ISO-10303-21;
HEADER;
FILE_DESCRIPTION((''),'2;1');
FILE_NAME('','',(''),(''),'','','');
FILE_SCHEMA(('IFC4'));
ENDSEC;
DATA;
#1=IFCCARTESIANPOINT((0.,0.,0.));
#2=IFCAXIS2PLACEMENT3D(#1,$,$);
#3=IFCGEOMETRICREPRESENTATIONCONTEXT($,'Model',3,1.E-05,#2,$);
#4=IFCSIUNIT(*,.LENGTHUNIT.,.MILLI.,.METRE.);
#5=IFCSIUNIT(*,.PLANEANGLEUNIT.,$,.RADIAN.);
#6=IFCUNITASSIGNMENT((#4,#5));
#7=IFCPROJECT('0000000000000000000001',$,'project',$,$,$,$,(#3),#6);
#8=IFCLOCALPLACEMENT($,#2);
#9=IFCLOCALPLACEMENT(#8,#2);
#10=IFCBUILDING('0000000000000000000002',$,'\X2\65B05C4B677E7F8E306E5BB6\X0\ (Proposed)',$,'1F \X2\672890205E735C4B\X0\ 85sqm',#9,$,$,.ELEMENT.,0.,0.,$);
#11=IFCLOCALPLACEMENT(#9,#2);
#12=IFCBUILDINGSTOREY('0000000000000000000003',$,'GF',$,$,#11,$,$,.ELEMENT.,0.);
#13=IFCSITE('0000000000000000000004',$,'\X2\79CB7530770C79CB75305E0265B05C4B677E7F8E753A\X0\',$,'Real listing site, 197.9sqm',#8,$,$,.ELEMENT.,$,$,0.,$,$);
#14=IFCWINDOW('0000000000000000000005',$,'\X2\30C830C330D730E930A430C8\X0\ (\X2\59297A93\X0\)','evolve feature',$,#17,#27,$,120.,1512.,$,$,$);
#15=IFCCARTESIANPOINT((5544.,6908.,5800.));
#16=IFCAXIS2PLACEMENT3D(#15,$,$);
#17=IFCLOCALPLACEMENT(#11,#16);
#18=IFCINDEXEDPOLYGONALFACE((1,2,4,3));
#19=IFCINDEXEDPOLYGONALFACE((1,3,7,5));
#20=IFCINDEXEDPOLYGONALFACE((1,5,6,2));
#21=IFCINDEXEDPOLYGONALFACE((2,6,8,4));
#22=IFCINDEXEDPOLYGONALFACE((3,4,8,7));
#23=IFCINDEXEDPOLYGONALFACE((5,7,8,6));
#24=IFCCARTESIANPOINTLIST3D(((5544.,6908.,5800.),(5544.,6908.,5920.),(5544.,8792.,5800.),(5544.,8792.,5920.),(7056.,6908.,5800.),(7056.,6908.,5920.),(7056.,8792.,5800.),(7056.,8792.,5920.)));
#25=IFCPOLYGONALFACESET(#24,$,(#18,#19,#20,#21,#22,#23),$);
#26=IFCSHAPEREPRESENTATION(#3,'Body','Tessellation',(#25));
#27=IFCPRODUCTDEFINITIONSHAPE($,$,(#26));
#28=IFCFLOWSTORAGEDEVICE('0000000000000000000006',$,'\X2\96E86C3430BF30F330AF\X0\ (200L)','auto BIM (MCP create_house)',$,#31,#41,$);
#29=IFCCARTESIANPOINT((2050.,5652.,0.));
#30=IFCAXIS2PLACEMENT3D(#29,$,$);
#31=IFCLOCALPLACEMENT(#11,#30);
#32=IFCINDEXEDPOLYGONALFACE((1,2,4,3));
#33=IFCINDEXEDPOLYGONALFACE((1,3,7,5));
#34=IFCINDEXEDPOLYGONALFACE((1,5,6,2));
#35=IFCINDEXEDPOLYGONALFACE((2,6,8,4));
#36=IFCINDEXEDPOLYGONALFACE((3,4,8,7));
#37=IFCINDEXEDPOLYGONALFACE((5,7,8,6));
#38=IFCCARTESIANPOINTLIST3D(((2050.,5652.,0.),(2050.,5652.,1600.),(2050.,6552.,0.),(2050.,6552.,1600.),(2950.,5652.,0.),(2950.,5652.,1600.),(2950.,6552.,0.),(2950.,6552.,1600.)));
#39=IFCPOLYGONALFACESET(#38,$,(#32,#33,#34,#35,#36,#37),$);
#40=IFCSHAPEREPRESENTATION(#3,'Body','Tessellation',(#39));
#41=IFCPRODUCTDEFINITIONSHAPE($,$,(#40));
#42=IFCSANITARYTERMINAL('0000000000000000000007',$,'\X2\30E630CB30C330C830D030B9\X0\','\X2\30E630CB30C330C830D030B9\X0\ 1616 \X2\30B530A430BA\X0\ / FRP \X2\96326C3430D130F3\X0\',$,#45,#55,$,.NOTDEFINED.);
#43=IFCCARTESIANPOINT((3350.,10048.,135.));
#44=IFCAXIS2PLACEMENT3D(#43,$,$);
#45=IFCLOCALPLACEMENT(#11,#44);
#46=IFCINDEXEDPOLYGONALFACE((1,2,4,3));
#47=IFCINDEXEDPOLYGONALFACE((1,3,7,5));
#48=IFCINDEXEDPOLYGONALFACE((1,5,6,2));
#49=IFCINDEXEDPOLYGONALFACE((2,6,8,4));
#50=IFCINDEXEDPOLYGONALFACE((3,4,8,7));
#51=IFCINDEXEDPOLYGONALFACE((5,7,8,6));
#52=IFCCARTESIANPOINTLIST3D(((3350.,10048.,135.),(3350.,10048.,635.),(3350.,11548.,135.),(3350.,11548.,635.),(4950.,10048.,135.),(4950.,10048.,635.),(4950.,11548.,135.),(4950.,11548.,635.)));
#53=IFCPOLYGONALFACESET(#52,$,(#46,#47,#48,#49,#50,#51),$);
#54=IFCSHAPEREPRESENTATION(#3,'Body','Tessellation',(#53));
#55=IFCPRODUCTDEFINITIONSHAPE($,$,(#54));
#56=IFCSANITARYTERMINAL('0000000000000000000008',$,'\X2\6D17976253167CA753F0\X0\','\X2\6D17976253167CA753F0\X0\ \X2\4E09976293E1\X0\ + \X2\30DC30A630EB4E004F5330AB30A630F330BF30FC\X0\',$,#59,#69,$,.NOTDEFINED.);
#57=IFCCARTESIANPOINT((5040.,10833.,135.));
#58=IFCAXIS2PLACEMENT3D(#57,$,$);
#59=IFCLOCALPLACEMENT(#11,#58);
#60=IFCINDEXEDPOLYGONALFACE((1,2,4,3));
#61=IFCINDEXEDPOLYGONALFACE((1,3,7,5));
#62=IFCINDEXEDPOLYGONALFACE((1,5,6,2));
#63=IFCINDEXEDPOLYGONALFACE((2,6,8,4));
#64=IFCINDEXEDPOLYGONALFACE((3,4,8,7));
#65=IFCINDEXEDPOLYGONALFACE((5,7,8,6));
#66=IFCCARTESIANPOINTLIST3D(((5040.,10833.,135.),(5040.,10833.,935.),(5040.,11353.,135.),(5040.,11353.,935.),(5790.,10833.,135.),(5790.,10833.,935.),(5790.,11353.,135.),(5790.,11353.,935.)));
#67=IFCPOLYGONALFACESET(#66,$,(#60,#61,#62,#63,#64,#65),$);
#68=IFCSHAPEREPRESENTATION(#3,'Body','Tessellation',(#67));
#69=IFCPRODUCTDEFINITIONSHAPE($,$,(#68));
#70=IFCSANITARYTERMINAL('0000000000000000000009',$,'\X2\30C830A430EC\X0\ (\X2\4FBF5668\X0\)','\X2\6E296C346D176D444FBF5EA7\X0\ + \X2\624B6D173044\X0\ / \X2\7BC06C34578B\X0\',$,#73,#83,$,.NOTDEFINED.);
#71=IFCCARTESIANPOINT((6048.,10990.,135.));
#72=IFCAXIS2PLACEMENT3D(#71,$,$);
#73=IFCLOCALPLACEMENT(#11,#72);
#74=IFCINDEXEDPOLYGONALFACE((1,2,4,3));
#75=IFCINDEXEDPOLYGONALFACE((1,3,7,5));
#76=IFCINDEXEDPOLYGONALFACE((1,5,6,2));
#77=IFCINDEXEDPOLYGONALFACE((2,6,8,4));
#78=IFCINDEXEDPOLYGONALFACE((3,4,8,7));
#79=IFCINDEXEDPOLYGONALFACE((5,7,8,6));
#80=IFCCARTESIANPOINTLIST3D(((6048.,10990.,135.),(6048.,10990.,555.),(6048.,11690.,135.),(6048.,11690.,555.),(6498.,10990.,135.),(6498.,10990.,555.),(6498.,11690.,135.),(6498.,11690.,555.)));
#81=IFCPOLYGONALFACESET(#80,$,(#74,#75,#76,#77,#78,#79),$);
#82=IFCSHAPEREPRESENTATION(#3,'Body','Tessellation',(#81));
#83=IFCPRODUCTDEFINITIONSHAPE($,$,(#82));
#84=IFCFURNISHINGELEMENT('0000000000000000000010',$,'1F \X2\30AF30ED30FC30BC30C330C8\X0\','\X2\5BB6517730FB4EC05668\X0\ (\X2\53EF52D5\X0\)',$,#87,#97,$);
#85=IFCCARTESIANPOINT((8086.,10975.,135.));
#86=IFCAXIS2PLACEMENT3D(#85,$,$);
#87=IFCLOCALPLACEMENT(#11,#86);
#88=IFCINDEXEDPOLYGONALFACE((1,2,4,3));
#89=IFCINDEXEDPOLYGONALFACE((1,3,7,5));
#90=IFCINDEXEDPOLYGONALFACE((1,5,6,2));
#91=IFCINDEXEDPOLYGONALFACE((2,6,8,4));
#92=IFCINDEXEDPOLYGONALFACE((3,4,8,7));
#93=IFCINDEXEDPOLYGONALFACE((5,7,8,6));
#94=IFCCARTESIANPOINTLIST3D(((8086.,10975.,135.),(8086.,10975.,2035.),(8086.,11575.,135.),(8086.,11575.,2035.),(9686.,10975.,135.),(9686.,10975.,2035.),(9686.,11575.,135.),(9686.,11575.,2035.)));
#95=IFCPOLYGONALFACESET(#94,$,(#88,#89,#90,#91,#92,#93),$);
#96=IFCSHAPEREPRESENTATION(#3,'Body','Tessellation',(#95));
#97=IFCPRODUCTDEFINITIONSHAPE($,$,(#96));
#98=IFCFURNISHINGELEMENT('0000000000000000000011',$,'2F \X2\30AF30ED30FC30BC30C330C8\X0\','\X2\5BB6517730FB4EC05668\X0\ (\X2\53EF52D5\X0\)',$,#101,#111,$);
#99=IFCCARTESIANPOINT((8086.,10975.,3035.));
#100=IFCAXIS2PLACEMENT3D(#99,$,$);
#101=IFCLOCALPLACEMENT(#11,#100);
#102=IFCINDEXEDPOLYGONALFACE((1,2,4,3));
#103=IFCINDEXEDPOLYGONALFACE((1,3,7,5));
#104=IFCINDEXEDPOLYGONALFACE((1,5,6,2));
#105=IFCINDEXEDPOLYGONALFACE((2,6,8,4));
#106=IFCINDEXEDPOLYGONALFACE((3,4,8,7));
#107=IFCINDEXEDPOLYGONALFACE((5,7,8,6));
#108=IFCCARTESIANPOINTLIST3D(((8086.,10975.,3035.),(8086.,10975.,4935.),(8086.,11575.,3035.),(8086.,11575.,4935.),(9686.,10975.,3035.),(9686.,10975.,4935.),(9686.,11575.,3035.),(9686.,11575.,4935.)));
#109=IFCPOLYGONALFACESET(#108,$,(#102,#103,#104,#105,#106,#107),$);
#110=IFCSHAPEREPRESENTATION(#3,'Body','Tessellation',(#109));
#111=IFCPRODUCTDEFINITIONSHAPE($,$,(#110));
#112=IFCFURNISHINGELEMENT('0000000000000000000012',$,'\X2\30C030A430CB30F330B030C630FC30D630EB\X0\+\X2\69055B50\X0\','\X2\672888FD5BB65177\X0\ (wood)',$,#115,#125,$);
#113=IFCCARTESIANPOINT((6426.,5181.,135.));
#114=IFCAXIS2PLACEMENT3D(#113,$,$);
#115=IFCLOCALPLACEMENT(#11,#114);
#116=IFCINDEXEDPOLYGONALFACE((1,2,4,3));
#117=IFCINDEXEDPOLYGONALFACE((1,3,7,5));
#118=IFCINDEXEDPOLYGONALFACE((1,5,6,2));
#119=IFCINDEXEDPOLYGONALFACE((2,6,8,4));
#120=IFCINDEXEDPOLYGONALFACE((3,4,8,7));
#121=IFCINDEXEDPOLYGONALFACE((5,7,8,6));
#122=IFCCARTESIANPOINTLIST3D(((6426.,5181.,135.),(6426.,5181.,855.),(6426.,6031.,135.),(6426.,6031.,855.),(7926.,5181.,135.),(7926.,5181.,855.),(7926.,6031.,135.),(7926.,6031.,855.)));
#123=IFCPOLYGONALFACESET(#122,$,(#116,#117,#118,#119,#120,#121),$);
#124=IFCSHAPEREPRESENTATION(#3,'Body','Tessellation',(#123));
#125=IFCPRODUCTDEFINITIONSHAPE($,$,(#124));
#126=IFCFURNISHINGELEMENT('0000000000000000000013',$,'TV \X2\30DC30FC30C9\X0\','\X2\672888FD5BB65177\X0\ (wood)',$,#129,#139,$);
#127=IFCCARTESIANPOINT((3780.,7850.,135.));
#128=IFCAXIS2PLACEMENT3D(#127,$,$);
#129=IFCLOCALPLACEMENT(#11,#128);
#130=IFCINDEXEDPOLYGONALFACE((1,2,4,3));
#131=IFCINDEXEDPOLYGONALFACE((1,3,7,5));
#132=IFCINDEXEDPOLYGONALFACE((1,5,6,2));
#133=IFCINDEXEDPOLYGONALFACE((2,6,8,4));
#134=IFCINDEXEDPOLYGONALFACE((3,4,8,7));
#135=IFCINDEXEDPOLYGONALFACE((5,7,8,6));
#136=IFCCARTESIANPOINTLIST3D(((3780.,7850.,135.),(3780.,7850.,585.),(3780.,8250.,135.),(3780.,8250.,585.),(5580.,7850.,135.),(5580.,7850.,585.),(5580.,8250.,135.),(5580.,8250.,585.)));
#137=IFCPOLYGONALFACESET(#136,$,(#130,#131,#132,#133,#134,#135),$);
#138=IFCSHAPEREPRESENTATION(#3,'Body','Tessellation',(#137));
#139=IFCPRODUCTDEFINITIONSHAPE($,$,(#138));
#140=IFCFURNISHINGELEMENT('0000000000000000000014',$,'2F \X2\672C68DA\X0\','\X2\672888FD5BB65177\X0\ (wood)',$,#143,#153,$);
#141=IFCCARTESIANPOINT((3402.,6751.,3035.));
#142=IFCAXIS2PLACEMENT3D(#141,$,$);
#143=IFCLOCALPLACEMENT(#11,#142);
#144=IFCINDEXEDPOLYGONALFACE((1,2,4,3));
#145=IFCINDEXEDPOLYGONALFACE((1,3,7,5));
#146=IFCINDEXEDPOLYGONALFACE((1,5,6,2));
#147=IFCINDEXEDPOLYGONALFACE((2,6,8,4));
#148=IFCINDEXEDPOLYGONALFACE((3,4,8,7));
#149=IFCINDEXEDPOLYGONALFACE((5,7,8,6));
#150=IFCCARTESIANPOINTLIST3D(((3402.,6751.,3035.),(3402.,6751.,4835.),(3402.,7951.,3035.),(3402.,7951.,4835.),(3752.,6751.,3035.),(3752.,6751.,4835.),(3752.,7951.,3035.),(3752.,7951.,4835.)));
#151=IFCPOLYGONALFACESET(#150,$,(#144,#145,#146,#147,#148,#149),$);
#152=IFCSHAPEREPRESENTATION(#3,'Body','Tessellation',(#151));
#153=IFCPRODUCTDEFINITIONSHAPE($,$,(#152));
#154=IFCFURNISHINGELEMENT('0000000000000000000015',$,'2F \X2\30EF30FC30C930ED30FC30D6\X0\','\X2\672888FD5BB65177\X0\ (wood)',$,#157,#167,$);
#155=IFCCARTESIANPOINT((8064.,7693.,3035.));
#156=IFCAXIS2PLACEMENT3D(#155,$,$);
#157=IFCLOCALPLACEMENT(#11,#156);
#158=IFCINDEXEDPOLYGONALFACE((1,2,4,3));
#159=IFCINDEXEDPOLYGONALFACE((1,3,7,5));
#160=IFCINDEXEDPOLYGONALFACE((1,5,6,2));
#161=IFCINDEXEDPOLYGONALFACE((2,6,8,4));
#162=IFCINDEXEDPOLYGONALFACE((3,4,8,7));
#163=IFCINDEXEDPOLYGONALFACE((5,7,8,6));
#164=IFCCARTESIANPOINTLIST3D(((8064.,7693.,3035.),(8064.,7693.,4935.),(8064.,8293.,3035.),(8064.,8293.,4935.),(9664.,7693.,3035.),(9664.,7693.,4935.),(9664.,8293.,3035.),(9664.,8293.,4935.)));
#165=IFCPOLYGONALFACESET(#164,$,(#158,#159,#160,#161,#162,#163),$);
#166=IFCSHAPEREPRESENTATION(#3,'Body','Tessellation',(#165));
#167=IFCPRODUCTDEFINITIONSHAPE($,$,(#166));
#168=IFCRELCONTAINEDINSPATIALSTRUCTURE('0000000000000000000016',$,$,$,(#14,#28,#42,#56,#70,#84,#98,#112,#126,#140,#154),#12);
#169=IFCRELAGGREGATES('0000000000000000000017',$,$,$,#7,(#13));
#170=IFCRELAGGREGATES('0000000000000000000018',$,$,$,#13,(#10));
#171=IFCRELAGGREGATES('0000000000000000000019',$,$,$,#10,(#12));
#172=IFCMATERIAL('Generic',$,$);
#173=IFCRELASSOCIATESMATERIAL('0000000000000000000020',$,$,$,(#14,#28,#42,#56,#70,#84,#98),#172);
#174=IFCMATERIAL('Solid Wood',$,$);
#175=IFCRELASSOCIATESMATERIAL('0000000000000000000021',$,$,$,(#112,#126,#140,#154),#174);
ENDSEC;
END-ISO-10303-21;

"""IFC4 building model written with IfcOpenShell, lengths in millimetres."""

from ifc_helpers import new_model, si_unit, frame, frame_2d, origin, place, context, project, spatial, rectangle, extrude, material, element, save


model = new_model("IFC4")

# Units and contexts
model_context = context("Model", 3, precision=1e-05, world=origin())
ifc_project = project(units=[si_unit("LENGTHUNIT", "METRE", prefix="MILLI"), si_unit("PLANEANGLEUNIT", "RADIAN")], contexts=[model_context])

# Site, building, storey
site_placement = place(None, origin())
site = spatial("IfcSite", under=ifc_project, at=site_placement, Name="秋田県秋田市新屋松美町", ObjectType="Real listing site, 197.9sqm", CompositionType="ELEMENT", RefElevation=0.0)
building_placement = place(site_placement, origin())
building = spatial("IfcBuilding", under=site, at=building_placement, Name="新屋松美の家 (Proposed)", ObjectType="1F 木造平屋 85sqm", CompositionType="ELEMENT", ElevationOfRefHeight=0.0, ElevationOfTerrain=0.0)
storey_placement = place(building_placement, origin())
storey = spatial("IfcBuildingStorey", under=building, at=storey_placement, Name="GF", CompositionType="ELEMENT", Elevation=0.0)

# Shared definitions
ifc_material_1 = material(Name="Solid Wood")

# Window
ifc_material_2 = material(Name="Generic")
window_1_placement = place(storey_placement, frame((5544.0, 6908.0, 5800.0)))
element("IfcWindow", 1, at=window_1_placement, inside=storey, material=ifc_material_2, Name="トップライト (天窓)", Description="evolve feature", OverallHeight=120.0, OverallWidth=1512.0, context=model_context, shape_type="SweptSolid", body=[
    extrude(rectangle(XDim=1512.0, YDim=1884.0, at=frame_2d((756.0, 942.0))), frame((5544.0, 6908.0, 5800.0)), (0.0, 0.0, 1.0), 120.0),
])

# Flow storage device
flow_storage_device_placement = place(storey_placement, frame((2050.0, 5652.0, 0.0)))
element("IfcFlowStorageDevice", 2, at=flow_storage_device_placement, inside=storey, material=ifc_material_2, Name="雨水タンク (200L)", Description="auto BIM (MCP create_house)", context=model_context, shape_type="SweptSolid", body=[
    extrude(rectangle(XDim=900.0, YDim=900.0, at=frame_2d((450.0, 450.0))), frame((2050.0, 5652.0, 0.0)), (0.0, 0.0, 1.0), 1600.0),
])

# Sanitary terminals
sanitary_terminal_1_placement = place(storey_placement, frame((3350.0, 10048.0, 135.0)))
element("IfcSanitaryTerminal", 3, at=sanitary_terminal_1_placement, inside=storey, material=ifc_material_2, Name="ユニットバス", Description="ユニットバス 1616 サイズ / FRP 防水パン", PredefinedType="NOTDEFINED", context=model_context, shape_type="SweptSolid", body=[
    extrude(rectangle(XDim=1600.0, YDim=1500.0, at=frame_2d((800.0, 750.0))), frame((3350.0, 10048.0, 135.0)), (0.0, 0.0, 1.0), 500.0),
])
sanitary_terminal_2_placement = place(storey_placement, frame((5040.0, 10833.0, 135.0)))
element("IfcSanitaryTerminal", 4, at=sanitary_terminal_2_placement, inside=storey, material=ifc_material_2, Name="洗面化粧台", Description="洗面化粧台 三面鏡 + ボウル一体カウンター", PredefinedType="NOTDEFINED", context=model_context, shape_type="SweptSolid", body=[
    extrude(rectangle(XDim=750.0, YDim=520.0, at=frame_2d((375.0, 260.0))), frame((5040.0, 10833.0, 135.0)), (0.0, 0.0, 1.0), 800.0),
])
sanitary_terminal_3_placement = place(storey_placement, frame((6048.0, 10990.0, 135.0)))
element("IfcSanitaryTerminal", 5, at=sanitary_terminal_3_placement, inside=storey, material=ifc_material_2, Name="トイレ (便器)", Description="温水洗浄便座 + 手洗い / 節水型", PredefinedType="NOTDEFINED", context=model_context, shape_type="SweptSolid", body=[
    extrude(rectangle(XDim=450.0, YDim=700.0, at=frame_2d((225.0, 350.0))), frame((6048.0, 10990.0, 135.0)), (0.0, 0.0, 1.0), 420.0),
])

# Furnishing elements
furnishing_1_placement = place(storey_placement, frame((8086.0, 10975.0, 135.0)))
element("IfcFurnishingElement", 6, at=furnishing_1_placement, inside=storey, material=ifc_material_2, Name="1F クローゼット", Description="家具・什器 (可動)", context=model_context, shape_type="SweptSolid", body=[
    extrude(rectangle(XDim=1600.0, YDim=600.0, at=frame_2d((800.0, 300.0))), frame((8086.0, 10975.0, 135.0)), (0.0, 0.0, 1.0), 1900.0),
])
furnishing_2_placement = place(storey_placement, frame((8086.0, 10975.0, 3035.0)))
element("IfcFurnishingElement", 7, at=furnishing_2_placement, inside=storey, material=ifc_material_2, Name="2F クローゼット", Description="家具・什器 (可動)", context=model_context, shape_type="SweptSolid", body=[
    extrude(rectangle(XDim=1600.0, YDim=600.0, at=frame_2d((800.0, 300.0))), frame((8086.0, 10975.0, 3035.0)), (0.0, 0.0, 1.0), 1900.0),
])
furnishing_3_placement = place(storey_placement, frame((6426.0, 5181.0, 135.0)))
element("IfcFurnishingElement", 8, at=furnishing_3_placement, inside=storey, material=ifc_material_1, Name="ダイニングテーブル+椅子", Description="木製家具 (wood)", context=model_context, shape_type="SweptSolid", body=[
    extrude(rectangle(XDim=1500.0, YDim=850.0, at=frame_2d((750.0, 425.0))), frame((6426.0, 5181.0, 135.0)), (0.0, 0.0, 1.0), 720.0),
])
furnishing_4_placement = place(storey_placement, frame((3780.0, 7850.0, 135.0)))
element("IfcFurnishingElement", 9, at=furnishing_4_placement, inside=storey, material=ifc_material_1, Name="TV ボード", Description="木製家具 (wood)", context=model_context, shape_type="SweptSolid", body=[
    extrude(rectangle(XDim=1800.0, YDim=400.0, at=frame_2d((900.0, 200.0))), frame((3780.0, 7850.0, 135.0)), (0.0, 0.0, 1.0), 450.0),
])
furnishing_5_placement = place(storey_placement, frame((3402.0, 6751.0, 3035.0)))
element("IfcFurnishingElement", 10, at=furnishing_5_placement, inside=storey, material=ifc_material_1, Name="2F 本棚", Description="木製家具 (wood)", context=model_context, shape_type="SweptSolid", body=[
    extrude(rectangle(XDim=350.0, YDim=1200.0, at=frame_2d((175.0, 600.0))), frame((3402.0, 6751.0, 3035.0)), (0.0, 0.0, 1.0), 1800.0),
])
furnishing_6_placement = place(storey_placement, frame((8064.0, 7693.0, 3035.0)))
element("IfcFurnishingElement", 11, at=furnishing_6_placement, inside=storey, material=ifc_material_1, Name="2F ワードローブ", Description="木製家具 (wood)", context=model_context, shape_type="SweptSolid", body=[
    extrude(rectangle(XDim=1600.0, YDim=600.0, at=frame_2d((800.0, 300.0))), frame((8064.0, 7693.0, 3035.0)), (0.0, 0.0, 1.0), 1900.0),
])

save(model, "model.ifc")
